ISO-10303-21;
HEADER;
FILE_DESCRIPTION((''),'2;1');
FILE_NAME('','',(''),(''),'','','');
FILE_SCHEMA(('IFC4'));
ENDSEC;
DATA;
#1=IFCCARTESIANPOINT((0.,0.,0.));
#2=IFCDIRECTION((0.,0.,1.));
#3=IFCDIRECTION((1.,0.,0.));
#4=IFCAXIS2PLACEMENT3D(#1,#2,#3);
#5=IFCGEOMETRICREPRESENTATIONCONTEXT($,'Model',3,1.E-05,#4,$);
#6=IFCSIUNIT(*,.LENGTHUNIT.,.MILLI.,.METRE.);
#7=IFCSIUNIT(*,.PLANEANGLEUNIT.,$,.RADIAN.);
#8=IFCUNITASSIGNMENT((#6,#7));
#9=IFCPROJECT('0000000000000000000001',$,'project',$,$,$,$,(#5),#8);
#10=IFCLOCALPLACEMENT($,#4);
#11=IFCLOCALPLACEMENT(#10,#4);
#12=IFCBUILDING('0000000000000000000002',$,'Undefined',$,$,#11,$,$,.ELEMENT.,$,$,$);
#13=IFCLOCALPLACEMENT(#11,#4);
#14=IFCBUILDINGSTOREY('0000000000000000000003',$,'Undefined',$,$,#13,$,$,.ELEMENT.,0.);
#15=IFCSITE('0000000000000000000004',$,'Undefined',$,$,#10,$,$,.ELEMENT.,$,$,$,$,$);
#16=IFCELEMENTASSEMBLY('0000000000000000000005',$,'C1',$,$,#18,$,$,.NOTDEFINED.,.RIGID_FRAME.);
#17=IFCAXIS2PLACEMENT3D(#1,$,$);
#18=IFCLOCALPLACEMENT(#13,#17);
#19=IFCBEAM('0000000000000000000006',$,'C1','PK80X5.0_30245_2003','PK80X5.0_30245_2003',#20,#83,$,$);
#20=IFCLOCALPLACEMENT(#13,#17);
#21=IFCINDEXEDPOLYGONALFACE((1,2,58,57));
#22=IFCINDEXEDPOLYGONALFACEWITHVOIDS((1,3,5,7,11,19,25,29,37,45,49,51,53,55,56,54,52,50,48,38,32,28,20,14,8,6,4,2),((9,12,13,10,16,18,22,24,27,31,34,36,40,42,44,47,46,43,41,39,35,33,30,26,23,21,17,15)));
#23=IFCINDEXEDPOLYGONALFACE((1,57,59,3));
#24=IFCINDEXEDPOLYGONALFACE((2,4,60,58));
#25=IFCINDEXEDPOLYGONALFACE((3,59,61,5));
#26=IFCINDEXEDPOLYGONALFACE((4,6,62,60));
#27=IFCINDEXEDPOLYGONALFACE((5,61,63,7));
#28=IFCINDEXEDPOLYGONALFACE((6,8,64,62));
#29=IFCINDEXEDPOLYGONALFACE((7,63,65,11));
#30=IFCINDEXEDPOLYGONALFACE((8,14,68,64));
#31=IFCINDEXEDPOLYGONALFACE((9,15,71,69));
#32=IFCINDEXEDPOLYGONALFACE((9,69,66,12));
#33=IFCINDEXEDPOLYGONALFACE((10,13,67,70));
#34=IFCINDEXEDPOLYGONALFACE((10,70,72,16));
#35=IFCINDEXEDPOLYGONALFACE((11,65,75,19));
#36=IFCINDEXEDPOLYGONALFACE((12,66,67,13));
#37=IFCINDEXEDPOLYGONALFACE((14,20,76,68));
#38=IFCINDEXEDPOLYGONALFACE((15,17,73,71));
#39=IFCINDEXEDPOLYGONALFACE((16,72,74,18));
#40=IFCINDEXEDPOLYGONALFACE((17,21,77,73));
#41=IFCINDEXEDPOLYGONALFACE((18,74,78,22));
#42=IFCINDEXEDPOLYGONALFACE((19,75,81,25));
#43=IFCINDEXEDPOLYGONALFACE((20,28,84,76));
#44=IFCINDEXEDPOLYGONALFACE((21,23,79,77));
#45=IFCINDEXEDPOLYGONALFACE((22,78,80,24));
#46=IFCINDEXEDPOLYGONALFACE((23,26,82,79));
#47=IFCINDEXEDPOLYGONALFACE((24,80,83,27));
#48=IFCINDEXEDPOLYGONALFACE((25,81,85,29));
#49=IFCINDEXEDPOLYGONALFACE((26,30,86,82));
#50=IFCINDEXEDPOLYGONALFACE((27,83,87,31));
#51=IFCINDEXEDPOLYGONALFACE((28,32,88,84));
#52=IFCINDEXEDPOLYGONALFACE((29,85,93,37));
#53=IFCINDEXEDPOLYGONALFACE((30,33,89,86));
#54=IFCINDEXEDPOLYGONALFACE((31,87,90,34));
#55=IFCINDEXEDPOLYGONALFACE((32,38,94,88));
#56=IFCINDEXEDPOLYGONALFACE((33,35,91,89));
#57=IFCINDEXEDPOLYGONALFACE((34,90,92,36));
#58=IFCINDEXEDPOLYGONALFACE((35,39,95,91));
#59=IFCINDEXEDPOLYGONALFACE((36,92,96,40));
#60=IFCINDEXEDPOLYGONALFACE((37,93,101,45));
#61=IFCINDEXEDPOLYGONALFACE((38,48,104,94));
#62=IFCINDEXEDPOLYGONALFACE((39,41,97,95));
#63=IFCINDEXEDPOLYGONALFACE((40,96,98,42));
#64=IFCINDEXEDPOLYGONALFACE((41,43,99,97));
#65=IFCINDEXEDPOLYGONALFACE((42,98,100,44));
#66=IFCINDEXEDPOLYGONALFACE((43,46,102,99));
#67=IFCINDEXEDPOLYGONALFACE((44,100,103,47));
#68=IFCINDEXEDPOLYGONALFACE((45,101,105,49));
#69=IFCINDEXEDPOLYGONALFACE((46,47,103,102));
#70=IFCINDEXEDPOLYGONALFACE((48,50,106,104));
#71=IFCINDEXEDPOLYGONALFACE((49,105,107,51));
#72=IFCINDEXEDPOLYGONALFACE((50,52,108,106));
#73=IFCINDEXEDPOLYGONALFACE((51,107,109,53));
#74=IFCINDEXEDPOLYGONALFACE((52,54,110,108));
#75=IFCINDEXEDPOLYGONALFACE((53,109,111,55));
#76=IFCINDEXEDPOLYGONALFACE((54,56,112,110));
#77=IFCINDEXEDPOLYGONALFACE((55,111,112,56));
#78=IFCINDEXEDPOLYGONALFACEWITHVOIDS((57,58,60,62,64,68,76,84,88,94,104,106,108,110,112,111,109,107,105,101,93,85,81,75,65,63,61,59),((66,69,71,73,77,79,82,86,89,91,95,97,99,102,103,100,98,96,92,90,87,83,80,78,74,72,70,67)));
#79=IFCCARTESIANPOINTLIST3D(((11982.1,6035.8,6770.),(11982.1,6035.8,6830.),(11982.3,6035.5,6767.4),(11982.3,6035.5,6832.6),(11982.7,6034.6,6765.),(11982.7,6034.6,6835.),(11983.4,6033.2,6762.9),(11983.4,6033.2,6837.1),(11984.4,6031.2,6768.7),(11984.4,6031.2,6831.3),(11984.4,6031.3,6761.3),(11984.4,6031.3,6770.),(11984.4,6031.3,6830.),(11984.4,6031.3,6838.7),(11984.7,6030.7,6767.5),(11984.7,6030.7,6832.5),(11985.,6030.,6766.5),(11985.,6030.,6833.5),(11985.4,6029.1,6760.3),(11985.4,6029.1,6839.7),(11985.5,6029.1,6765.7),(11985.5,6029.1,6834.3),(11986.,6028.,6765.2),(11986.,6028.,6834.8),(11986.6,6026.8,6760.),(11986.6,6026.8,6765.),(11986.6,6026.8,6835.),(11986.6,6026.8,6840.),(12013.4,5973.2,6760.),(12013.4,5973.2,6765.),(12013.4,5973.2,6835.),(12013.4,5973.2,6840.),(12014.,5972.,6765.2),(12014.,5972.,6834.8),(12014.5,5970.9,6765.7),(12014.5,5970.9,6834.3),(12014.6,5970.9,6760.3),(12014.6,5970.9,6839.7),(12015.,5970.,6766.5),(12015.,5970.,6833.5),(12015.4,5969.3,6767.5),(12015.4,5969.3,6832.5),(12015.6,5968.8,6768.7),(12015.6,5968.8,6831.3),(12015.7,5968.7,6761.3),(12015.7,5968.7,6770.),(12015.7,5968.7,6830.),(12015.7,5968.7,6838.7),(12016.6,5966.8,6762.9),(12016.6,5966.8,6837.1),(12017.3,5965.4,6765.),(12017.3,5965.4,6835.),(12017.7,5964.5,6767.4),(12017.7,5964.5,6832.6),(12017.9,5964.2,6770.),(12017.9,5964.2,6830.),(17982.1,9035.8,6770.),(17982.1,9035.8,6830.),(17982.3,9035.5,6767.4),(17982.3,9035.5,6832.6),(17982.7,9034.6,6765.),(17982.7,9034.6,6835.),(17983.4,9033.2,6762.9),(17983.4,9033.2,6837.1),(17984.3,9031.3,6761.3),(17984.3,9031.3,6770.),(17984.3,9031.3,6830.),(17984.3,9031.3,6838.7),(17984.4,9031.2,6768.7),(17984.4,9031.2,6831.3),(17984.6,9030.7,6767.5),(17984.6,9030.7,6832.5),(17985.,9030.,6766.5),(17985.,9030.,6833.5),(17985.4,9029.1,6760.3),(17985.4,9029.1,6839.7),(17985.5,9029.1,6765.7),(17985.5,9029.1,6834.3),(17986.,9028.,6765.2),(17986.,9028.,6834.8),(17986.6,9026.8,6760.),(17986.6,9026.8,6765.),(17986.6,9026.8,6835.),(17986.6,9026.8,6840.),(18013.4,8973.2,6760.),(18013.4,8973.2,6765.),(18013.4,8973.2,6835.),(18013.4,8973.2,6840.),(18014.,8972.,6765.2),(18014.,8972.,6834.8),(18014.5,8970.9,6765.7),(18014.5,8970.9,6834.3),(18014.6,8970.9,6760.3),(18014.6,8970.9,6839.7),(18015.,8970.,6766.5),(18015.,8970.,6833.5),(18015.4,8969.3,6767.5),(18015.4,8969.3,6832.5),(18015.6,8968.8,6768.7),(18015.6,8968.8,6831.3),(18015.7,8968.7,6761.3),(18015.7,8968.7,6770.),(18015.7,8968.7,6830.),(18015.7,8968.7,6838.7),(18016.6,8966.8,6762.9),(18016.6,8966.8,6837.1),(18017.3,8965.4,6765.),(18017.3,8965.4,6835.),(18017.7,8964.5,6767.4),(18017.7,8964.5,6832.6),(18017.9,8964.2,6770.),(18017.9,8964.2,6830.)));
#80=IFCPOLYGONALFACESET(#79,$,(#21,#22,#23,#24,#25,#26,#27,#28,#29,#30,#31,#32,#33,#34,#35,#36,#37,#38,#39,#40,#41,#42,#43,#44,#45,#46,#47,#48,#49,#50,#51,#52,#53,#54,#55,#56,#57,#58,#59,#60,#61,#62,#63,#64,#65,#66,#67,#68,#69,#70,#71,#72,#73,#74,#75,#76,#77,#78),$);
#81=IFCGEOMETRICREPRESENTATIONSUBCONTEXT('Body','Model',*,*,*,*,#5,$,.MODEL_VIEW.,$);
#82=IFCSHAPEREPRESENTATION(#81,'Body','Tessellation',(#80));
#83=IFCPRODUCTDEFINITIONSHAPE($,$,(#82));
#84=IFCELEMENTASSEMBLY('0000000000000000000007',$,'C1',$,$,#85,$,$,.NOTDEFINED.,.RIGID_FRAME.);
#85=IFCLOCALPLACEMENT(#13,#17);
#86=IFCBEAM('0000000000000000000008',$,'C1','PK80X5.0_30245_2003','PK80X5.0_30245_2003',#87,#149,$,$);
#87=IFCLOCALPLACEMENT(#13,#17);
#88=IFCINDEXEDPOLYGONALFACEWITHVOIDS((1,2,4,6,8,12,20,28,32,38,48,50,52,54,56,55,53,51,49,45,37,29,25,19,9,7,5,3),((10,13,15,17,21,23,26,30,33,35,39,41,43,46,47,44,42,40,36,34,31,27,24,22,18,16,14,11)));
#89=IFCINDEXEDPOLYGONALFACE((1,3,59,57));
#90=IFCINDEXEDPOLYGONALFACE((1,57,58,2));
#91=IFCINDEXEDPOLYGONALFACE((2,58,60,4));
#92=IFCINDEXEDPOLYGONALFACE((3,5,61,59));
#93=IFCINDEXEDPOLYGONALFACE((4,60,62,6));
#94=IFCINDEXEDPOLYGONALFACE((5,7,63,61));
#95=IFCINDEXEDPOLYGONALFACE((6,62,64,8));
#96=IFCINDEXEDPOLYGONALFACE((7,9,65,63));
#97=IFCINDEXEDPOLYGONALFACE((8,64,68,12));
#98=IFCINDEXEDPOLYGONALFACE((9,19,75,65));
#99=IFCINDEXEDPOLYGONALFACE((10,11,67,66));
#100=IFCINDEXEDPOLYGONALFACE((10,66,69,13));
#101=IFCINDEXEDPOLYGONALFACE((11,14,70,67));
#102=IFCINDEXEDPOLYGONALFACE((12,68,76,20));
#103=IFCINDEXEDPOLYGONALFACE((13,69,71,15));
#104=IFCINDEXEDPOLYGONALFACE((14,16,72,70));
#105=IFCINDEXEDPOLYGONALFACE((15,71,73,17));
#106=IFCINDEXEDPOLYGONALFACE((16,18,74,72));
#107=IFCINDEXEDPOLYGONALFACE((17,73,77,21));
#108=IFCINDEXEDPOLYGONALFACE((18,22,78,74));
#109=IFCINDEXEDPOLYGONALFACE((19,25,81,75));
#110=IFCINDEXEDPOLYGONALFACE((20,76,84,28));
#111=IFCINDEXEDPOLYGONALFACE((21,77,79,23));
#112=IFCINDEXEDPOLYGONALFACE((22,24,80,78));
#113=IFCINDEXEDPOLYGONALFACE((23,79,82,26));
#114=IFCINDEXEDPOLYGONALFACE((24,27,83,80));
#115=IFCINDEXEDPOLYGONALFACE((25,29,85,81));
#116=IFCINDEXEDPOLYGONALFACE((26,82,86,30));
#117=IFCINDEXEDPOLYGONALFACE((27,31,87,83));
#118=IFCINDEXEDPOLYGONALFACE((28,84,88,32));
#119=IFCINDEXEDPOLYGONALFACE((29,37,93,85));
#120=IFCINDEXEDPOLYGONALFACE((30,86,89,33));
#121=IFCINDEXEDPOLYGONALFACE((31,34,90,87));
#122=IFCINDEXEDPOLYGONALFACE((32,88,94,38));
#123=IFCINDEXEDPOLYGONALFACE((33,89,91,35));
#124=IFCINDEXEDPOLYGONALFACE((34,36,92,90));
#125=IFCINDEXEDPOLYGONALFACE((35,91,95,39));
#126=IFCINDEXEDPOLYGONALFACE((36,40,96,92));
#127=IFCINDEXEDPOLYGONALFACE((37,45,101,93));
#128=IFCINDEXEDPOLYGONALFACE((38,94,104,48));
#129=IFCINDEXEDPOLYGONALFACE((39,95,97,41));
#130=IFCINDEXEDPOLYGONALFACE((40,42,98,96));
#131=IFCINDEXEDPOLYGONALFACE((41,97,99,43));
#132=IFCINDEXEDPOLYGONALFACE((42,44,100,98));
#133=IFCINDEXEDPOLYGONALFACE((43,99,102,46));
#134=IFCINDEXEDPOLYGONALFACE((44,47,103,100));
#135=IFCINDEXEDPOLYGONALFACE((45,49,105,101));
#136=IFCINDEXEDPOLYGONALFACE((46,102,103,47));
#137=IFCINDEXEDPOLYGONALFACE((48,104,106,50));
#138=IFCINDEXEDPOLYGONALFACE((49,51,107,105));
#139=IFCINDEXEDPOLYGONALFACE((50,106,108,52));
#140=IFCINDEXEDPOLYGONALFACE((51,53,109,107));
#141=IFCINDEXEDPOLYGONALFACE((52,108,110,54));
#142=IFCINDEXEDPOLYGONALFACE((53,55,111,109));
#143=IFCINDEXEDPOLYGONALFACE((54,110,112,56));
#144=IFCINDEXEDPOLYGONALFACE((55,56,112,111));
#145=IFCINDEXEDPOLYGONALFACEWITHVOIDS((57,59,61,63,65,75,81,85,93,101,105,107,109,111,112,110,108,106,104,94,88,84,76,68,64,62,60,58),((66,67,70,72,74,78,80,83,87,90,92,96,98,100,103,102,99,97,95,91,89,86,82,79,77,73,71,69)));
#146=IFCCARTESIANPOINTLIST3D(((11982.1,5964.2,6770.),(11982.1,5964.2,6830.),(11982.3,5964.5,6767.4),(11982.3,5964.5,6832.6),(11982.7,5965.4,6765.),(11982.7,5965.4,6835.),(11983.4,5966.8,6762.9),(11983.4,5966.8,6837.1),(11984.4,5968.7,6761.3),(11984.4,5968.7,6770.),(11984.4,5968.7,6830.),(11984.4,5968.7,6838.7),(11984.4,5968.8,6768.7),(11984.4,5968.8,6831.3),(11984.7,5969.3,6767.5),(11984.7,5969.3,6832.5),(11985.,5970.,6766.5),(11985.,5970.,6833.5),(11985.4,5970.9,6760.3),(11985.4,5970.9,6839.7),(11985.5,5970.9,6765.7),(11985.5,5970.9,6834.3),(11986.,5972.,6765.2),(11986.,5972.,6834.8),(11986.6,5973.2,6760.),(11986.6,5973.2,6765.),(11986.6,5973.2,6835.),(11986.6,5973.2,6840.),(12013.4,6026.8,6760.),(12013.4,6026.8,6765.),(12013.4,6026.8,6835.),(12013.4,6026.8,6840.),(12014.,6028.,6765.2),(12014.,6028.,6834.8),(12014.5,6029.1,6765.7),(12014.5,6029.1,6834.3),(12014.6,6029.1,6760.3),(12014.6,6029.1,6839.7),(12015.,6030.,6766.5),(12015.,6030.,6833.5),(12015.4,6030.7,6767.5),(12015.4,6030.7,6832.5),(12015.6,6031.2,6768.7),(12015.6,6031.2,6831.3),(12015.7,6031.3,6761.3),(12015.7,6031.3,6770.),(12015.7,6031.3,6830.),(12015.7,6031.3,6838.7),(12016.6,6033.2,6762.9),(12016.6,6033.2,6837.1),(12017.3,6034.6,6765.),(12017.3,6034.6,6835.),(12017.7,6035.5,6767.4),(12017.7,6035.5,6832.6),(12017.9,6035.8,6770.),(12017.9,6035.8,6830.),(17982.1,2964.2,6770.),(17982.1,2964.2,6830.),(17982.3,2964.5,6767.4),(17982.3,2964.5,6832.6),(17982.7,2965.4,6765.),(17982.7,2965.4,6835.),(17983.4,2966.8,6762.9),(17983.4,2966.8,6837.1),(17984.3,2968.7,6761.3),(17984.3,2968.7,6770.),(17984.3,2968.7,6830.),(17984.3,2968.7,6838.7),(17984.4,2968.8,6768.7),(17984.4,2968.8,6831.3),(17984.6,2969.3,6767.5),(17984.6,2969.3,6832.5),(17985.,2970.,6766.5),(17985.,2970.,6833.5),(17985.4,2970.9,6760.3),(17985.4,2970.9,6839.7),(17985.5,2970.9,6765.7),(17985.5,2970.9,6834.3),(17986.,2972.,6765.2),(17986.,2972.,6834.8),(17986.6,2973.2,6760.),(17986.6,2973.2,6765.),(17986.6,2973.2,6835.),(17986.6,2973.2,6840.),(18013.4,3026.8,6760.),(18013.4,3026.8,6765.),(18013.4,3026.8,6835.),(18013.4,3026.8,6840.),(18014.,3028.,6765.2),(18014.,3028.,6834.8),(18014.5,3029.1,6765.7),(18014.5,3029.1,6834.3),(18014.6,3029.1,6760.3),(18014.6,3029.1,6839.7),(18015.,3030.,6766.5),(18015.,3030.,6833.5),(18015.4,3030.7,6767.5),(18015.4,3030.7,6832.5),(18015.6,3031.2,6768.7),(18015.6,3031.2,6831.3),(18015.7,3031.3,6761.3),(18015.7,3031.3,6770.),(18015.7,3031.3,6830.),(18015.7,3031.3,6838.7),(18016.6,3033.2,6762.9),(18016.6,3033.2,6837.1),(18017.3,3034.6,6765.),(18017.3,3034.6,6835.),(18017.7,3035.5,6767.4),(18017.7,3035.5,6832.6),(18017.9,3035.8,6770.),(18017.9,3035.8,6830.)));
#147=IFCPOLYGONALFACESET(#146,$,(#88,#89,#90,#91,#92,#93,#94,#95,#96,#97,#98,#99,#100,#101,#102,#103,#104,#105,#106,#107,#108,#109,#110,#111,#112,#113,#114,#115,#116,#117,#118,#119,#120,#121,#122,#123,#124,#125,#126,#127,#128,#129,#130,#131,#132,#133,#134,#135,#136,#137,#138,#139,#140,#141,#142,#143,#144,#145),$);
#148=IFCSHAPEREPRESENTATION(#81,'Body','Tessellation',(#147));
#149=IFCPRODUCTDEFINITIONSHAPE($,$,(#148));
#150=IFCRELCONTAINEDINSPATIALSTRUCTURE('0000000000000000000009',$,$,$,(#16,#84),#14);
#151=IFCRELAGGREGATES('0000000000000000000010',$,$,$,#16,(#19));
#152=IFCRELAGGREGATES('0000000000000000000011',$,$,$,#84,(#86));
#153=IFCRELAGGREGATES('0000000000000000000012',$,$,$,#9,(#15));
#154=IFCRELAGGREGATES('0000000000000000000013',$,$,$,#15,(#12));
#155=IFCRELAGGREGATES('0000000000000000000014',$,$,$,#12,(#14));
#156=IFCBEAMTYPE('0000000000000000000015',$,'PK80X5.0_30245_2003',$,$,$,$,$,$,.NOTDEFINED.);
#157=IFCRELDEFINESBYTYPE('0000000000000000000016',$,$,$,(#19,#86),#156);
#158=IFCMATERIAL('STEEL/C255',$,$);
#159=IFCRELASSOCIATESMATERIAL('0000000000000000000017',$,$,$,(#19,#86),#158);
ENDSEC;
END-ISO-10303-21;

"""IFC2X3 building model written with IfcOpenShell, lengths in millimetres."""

from ifc_helpers import new_model, si_unit, frame, origin_with_axes, origin_2d_with_axis, place, context, subcontext, project, spatial, hollow_rectangle, extrude, material, type_object, element, aggregate, save


model = new_model("IFC2X3")

# Units and contexts
model_context = context("Model", 3, precision=1e-05, world=origin_with_axes())
body_context = subcontext(model_context, "Body", "Model", "MODEL_VIEW")
ifc_project = project(units=[si_unit("LENGTHUNIT", "METRE", prefix="MILLI"), si_unit("PLANEANGLEUNIT", "RADIAN")], contexts=[model_context])

# Site, building, storey
site_placement = place(None, origin_with_axes())
site = spatial("IfcSite", under=ifc_project, at=site_placement, Name="Undefined", CompositionType="ELEMENT")
building_placement = place(site_placement, origin_with_axes())
building = spatial("IfcBuilding", under=site, at=building_placement, Name="Undefined", CompositionType="ELEMENT")
storey_placement = place(building_placement, origin_with_axes())
storey = spatial("IfcBuildingStorey", under=building, at=storey_placement, Name="Undefined", CompositionType="ELEMENT", Elevation=0.0)

# Element assemblies, beams
assembly_1_placement = place(storey_placement, origin_with_axes())
assembly_1 = element("IfcElementAssembly", 1, at=assembly_1_placement, inside=storey, Name="C1", AssemblyPlace="NOTDEFINED", PredefinedType="RIGID_FRAME")
ifc_material_1 = material(Name="STEEL/C255")
beam_type_1 = type_object("IfcBeamType", Name="PK80X5.0_30245_2003", PredefinedType="NOTDEFINED")
beam_1_placement = place(assembly_1_placement, frame((12000.0, 6000.0, 6800.0), z_axis=(0.0, 0.0, -1.0), x_axis=(0.894427, 0.447214, 0.0)))
beam_1 = element("IfcBeam", 2, at=beam_1_placement, type_object=beam_type_1, material=ifc_material_1, Name="C1", Description="PK80X5.0_30245_2003", ObjectType="PK80X5.0_30245_2003", context=body_context, shape_type="SweptSolid", body=[
    extrude(hollow_rectangle(XDim=80.0, YDim=80.0, WallThickness=5.0, InnerFilletRadius=5.0, OuterFilletRadius=10.0, at=origin_2d_with_axis()), frame((6708.2, 0.0, 0.0), z_axis=(-1.0, 0.0, 0.0), x_axis=(0.0, -1.0, 0.0)), (0.0, 0.0, 1.0), 6708.2),
])
aggregate(assembly_1, [beam_1])
assembly_2_placement = place(storey_placement, origin_with_axes())
assembly_2 = element("IfcElementAssembly", 3, at=assembly_2_placement, inside=storey, Name="C1", AssemblyPlace="NOTDEFINED", PredefinedType="RIGID_FRAME")
beam_2_placement = place(assembly_2_placement, frame((12000.0, 6000.0, 6800.0), z_axis=(0.0, 0.0, -1.0), x_axis=(0.894427, -0.447214, 0.0)))
beam_2 = element("IfcBeam", 4, at=beam_2_placement, type_object=beam_type_1, material=ifc_material_1, Name="C1", Description="PK80X5.0_30245_2003", ObjectType="PK80X5.0_30245_2003", context=body_context, shape_type="SweptSolid", body=[
    extrude(hollow_rectangle(XDim=80.0, YDim=80.0, WallThickness=5.0, InnerFilletRadius=5.0, OuterFilletRadius=10.0, at=origin_2d_with_axis()), frame((6708.2, 0.0, 0.0), z_axis=(-1.0, 0.0, 0.0), x_axis=(0.0, -1.0, 0.0)), (0.0, 0.0, 1.0), 6708.2),
])
aggregate(assembly_2, [beam_2])

save(model, "model.ifc")
